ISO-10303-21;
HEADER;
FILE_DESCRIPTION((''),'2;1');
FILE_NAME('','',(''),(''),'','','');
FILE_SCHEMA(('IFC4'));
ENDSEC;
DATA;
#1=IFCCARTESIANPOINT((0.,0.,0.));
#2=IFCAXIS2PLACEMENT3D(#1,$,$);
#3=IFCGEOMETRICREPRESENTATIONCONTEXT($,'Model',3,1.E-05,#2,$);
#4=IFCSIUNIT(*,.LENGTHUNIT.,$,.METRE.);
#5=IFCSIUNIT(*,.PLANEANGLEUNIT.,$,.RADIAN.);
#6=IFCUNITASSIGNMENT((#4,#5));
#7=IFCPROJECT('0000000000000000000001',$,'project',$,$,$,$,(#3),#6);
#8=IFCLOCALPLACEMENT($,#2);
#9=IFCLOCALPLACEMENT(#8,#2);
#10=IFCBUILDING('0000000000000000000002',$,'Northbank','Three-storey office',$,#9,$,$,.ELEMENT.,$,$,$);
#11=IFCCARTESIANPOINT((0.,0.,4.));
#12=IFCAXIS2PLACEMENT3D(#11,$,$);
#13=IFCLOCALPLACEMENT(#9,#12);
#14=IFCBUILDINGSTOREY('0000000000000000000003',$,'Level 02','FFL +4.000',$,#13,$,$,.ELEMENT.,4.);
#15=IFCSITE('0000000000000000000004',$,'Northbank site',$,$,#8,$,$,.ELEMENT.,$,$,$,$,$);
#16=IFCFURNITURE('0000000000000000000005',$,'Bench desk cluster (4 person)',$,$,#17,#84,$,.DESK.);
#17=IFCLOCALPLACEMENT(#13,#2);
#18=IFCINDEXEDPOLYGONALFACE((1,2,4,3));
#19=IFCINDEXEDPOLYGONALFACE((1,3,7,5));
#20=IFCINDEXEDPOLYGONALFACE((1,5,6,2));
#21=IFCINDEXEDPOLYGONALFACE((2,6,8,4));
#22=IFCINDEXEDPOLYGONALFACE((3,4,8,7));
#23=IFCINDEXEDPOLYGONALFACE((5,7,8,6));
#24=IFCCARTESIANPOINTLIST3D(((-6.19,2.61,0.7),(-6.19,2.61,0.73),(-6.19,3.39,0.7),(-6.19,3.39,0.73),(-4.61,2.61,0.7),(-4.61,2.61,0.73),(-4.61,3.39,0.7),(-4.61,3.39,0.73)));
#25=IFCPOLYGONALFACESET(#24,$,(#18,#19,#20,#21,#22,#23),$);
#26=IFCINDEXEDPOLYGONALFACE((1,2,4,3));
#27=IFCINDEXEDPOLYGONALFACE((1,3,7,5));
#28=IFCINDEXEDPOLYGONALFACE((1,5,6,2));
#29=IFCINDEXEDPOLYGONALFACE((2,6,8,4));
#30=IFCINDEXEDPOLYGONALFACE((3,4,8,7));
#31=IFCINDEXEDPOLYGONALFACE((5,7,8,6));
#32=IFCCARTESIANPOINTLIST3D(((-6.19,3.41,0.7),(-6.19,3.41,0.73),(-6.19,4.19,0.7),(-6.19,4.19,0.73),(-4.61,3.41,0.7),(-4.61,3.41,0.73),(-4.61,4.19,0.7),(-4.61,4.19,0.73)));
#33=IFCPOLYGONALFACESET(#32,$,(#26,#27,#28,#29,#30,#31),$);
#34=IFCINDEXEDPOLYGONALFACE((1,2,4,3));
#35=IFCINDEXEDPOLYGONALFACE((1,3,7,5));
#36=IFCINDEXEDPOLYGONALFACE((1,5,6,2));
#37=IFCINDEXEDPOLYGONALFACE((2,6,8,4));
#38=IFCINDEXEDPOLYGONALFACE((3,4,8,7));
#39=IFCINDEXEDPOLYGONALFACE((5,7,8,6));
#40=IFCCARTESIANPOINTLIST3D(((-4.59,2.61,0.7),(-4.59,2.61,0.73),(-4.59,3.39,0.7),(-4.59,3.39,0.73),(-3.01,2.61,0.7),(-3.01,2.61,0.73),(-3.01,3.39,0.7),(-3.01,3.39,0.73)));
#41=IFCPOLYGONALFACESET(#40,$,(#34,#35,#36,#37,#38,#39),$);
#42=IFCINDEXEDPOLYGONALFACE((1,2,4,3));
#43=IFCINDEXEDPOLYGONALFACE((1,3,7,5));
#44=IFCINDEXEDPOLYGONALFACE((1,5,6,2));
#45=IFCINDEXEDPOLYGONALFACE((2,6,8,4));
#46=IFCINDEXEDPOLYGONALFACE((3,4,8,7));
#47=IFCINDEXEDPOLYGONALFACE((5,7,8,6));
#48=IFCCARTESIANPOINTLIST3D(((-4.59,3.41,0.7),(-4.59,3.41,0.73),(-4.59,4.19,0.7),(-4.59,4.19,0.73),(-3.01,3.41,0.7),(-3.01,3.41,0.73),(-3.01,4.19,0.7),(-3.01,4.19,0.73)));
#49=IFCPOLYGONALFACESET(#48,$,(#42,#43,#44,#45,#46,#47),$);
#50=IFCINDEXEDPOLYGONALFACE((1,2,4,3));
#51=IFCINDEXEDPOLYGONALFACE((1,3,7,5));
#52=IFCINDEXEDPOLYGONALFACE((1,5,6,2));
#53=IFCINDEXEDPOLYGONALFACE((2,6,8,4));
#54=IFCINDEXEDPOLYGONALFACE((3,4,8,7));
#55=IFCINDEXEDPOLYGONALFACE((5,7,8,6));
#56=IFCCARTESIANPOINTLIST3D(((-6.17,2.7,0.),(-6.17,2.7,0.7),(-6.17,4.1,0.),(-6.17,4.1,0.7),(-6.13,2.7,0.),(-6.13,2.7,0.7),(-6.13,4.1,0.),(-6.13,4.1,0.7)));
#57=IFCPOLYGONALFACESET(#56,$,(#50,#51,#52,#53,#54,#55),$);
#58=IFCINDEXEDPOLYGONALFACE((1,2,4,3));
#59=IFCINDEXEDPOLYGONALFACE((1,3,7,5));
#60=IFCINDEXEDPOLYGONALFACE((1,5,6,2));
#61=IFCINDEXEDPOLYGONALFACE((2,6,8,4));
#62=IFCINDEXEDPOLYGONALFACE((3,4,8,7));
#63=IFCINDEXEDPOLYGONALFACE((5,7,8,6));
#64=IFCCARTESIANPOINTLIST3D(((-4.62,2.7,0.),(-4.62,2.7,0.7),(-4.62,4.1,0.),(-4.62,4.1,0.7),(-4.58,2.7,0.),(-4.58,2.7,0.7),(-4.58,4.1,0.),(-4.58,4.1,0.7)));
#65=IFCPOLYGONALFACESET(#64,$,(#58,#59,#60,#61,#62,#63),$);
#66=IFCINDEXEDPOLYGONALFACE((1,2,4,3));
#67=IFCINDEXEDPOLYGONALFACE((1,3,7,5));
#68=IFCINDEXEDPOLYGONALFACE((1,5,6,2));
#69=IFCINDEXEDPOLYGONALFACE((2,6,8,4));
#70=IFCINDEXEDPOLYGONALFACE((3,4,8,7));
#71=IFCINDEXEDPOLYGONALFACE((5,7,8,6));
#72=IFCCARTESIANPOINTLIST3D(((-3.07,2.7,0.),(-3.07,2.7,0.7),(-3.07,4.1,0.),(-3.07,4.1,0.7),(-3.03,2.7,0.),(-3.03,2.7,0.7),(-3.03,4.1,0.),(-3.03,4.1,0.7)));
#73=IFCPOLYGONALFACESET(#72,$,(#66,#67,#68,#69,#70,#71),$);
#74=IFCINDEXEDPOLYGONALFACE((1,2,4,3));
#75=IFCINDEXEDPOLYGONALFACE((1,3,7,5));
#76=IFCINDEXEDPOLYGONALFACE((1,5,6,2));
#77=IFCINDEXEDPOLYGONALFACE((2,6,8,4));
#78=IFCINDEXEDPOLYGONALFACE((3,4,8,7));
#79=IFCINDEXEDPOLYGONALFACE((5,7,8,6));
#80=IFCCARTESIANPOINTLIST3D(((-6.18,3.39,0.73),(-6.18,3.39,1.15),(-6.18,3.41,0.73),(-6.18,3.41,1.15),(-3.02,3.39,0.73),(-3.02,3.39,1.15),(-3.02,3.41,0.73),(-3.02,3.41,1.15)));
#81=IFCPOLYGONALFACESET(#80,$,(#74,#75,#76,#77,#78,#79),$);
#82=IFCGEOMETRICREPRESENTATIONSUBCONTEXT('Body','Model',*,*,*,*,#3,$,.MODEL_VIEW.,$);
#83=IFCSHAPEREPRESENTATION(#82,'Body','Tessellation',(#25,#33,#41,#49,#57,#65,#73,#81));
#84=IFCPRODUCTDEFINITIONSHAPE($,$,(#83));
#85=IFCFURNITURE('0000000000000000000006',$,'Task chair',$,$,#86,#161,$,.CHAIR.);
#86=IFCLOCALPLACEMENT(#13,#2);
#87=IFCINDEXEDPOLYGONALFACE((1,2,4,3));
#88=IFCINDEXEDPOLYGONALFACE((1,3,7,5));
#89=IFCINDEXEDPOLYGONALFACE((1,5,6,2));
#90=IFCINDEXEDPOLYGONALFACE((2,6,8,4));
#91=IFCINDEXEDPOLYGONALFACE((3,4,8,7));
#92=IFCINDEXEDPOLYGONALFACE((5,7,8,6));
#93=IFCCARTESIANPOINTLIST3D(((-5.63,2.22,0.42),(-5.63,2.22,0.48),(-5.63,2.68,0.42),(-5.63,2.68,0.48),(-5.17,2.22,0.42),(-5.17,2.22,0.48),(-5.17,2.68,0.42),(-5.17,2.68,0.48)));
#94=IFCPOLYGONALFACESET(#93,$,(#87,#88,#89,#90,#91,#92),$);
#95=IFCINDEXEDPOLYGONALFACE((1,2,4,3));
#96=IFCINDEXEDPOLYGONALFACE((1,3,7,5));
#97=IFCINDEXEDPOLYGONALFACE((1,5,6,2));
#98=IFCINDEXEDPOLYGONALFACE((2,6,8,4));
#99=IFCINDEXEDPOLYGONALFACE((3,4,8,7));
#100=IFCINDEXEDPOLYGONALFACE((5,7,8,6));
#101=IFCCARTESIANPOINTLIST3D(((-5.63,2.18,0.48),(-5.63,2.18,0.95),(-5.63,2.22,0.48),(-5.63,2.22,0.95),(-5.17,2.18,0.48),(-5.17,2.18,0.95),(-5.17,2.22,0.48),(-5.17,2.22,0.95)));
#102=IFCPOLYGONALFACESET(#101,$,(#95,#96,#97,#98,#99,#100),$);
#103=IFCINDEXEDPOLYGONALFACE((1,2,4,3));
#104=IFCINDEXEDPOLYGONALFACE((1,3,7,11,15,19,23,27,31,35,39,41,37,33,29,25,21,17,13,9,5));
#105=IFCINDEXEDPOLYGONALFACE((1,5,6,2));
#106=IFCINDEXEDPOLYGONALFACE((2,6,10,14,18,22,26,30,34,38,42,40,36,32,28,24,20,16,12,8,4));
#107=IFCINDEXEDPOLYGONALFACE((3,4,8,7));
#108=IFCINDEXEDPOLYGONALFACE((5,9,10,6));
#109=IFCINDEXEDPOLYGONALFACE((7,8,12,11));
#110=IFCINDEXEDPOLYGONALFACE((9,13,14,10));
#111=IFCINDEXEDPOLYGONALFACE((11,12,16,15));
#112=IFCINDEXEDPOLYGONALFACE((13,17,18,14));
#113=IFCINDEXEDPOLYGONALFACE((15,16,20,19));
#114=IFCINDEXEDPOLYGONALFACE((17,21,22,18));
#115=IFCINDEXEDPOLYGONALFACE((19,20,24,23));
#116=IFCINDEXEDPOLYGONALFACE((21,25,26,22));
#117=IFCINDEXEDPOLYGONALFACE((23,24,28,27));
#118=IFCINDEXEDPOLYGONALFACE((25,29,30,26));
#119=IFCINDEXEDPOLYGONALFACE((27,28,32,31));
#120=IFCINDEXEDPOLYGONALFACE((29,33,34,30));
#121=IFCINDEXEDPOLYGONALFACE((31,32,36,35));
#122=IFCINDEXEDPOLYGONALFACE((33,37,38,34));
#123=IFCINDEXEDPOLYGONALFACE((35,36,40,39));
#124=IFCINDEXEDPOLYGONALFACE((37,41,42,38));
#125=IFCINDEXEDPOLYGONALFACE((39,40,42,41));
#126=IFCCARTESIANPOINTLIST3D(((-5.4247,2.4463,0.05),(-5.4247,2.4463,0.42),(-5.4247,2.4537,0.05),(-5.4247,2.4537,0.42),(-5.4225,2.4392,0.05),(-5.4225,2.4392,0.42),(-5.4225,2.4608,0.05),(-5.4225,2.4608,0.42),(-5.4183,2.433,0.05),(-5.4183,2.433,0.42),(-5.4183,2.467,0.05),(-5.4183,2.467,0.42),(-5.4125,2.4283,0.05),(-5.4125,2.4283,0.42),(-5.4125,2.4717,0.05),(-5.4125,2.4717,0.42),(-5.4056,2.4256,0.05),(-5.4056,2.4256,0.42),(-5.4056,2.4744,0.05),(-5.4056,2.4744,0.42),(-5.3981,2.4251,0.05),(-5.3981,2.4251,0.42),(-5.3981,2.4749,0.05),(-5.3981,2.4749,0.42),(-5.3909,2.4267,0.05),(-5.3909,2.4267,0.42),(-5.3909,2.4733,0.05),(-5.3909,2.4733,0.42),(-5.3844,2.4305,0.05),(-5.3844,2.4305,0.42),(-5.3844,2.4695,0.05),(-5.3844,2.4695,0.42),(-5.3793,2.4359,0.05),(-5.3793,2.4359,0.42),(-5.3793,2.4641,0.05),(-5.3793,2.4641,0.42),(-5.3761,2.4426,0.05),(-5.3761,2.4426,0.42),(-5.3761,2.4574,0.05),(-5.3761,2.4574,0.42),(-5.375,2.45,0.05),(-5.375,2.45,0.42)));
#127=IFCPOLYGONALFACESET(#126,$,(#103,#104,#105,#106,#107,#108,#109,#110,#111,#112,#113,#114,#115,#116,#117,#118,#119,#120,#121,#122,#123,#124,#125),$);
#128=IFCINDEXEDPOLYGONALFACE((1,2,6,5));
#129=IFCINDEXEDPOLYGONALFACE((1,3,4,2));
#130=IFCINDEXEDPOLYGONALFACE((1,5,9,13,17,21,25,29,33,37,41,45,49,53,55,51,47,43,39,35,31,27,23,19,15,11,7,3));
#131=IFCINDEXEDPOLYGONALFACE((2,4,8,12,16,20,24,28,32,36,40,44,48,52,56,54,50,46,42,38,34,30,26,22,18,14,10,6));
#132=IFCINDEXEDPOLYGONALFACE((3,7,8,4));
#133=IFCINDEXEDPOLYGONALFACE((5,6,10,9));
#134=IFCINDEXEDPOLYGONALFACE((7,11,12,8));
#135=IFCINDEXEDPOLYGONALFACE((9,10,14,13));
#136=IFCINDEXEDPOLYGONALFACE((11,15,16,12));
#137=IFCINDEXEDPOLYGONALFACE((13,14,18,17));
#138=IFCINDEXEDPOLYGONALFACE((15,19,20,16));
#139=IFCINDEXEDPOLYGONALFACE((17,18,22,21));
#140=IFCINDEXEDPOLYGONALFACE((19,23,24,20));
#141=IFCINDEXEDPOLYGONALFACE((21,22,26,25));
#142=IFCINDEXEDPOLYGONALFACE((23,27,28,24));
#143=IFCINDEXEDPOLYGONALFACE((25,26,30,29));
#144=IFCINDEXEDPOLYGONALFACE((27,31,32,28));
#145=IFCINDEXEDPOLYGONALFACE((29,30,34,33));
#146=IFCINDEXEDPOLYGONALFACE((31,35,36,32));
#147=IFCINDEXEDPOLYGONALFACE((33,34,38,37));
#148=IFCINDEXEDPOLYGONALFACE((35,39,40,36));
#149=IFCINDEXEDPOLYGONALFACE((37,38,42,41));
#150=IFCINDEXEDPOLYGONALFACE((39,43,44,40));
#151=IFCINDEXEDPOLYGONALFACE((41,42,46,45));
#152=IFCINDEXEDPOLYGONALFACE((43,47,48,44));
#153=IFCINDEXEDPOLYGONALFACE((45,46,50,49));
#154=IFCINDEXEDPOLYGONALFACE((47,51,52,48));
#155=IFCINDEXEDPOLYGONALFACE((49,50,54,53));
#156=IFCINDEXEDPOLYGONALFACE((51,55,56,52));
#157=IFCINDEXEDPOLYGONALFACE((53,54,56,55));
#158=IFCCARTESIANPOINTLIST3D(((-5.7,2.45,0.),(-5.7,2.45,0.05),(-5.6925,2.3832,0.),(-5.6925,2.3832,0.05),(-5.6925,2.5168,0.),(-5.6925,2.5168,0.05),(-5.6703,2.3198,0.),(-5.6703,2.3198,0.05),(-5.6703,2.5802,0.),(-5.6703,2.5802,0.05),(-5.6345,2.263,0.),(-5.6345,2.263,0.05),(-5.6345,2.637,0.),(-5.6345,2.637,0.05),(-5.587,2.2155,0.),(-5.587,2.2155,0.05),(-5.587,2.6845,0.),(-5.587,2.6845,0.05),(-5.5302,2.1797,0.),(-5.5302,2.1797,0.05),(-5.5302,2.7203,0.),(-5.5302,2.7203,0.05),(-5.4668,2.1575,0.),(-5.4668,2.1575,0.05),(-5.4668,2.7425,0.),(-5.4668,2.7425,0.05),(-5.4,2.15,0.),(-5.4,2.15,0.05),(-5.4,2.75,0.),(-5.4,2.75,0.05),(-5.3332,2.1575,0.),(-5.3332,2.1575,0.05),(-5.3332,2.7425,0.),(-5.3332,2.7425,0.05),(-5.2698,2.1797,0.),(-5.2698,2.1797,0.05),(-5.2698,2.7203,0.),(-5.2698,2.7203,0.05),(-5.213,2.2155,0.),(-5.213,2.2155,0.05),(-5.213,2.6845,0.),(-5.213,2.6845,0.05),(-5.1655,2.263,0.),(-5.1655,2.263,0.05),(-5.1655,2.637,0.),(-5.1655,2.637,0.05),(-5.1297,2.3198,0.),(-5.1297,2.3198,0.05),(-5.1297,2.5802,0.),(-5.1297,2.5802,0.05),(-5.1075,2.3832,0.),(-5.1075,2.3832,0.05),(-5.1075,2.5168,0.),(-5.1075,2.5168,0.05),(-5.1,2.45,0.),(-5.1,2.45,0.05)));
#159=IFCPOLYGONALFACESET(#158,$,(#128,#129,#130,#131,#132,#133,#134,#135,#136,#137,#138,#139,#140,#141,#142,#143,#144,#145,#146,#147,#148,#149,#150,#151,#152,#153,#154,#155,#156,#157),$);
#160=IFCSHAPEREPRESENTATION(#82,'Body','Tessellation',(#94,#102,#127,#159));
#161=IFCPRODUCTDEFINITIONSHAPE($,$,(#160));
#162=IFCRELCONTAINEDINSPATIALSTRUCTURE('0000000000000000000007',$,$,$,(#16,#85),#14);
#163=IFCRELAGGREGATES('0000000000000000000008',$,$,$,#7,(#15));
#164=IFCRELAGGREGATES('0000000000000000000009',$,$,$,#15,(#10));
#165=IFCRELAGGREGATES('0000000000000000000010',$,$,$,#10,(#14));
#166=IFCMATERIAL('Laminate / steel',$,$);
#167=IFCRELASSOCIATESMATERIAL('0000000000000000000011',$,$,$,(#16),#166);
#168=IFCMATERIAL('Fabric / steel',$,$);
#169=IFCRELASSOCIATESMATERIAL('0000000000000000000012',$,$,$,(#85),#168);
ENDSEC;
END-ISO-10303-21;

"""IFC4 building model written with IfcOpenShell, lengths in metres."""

from ifc_helpers import new_model, si_unit, frame, origin, place, context, subcontext, project, spatial, rectangle, circle, extrude, material, element, save


model = new_model("IFC4")

# Units and contexts
model_context = context("Model", 3, precision=1e-05, world=origin())
body_context = subcontext(model_context, "Body", "Model", "MODEL_VIEW")
ifc_project = project(units=[si_unit("LENGTHUNIT", "METRE"), si_unit("PLANEANGLEUNIT", "RADIAN")], contexts=[model_context])

# Site, building, storey
site_placement = place(None, origin())
site = spatial("IfcSite", under=ifc_project, at=site_placement, Name="Northbank site", CompositionType="ELEMENT")
building_placement = place(site_placement, origin())
building = spatial("IfcBuilding", under=site, at=building_placement, Name="Northbank", Description="Three-storey office", CompositionType="ELEMENT")
storey_placement = place(building_placement, frame((0.0, 0.0, 4.0)))
storey = spatial("IfcBuildingStorey", under=building, at=storey_placement, Name="Level 02", Description="FFL +4.000", CompositionType="ELEMENT", Elevation=4.0)

# Furniture
ifc_material_1 = material(Name="Laminate / steel")
furniture_1_placement = place(storey_placement, frame((0.0, 0.0, -4.0)))
element("IfcFurniture", 1, at=furniture_1_placement, inside=storey, material=ifc_material_1, Name="Bench desk cluster (4 person)", PredefinedType="DESK", context=body_context, shape_type="SweptSolid", body=[
    extrude(rectangle(XDim=1.58, YDim=0.78), frame((-5.4, 3.0, 4.7)), (0.0, 0.0, 1.0), 0.03),
    extrude(rectangle(XDim=1.58, YDim=0.78), frame((-5.4, 3.8, 4.7)), (0.0, 0.0, 1.0), 0.03),
    extrude(rectangle(XDim=1.58, YDim=0.78), frame((-3.8, 3.0, 4.7)), (0.0, 0.0, 1.0), 0.03),
    extrude(rectangle(XDim=1.58, YDim=0.78), frame((-3.8, 3.8, 4.7)), (0.0, 0.0, 1.0), 0.03),
    extrude(rectangle(XDim=0.04, YDim=1.4), frame((-6.15, 3.4, 4.0)), (0.0, 0.0, 1.0), 0.7),
    extrude(rectangle(XDim=0.04, YDim=1.4), frame((-4.6, 3.4, 4.0)), (0.0, 0.0, 1.0), 0.7),
    extrude(rectangle(XDim=0.04, YDim=1.4), frame((-3.05, 3.4, 4.0)), (0.0, 0.0, 1.0), 0.7),
    extrude(rectangle(XDim=3.16, YDim=0.02), frame((-4.6, 3.4, 4.73)), (0.0, 0.0, 1.0), 0.42),
])
ifc_material_2 = material(Name="Fabric / steel")
furniture_2_placement = place(storey_placement, frame((0.0, 0.0, -4.0)))
element("IfcFurniture", 2, at=furniture_2_placement, inside=storey, material=ifc_material_2, Name="Task chair", PredefinedType="CHAIR", context=body_context, shape_type="SweptSolid", body=[
    extrude(rectangle(XDim=0.46, YDim=0.46), frame((-5.4, 2.45, 4.42)), (0.0, 0.0, 1.0), 0.06),
    extrude(rectangle(XDim=0.46, YDim=0.04), frame((-5.4, 2.2, 4.48)), (0.0, 0.0, 1.0), 0.47),
    extrude(circle(Radius=0.025), frame((-5.4, 2.45, 4.05), z_axis=(0.0, 0.0, 1.0), x_axis=(1.0, 0.0, 0.0)), (0.0, 0.0, 1.0), 0.37),
    extrude(circle(Radius=0.3), frame((-5.4, 2.45, 4.0), z_axis=(0.0, 0.0, 1.0), x_axis=(1.0, 0.0, 0.0)), (0.0, 0.0, 1.0), 0.05),
])

save(model, "model.ifc")
